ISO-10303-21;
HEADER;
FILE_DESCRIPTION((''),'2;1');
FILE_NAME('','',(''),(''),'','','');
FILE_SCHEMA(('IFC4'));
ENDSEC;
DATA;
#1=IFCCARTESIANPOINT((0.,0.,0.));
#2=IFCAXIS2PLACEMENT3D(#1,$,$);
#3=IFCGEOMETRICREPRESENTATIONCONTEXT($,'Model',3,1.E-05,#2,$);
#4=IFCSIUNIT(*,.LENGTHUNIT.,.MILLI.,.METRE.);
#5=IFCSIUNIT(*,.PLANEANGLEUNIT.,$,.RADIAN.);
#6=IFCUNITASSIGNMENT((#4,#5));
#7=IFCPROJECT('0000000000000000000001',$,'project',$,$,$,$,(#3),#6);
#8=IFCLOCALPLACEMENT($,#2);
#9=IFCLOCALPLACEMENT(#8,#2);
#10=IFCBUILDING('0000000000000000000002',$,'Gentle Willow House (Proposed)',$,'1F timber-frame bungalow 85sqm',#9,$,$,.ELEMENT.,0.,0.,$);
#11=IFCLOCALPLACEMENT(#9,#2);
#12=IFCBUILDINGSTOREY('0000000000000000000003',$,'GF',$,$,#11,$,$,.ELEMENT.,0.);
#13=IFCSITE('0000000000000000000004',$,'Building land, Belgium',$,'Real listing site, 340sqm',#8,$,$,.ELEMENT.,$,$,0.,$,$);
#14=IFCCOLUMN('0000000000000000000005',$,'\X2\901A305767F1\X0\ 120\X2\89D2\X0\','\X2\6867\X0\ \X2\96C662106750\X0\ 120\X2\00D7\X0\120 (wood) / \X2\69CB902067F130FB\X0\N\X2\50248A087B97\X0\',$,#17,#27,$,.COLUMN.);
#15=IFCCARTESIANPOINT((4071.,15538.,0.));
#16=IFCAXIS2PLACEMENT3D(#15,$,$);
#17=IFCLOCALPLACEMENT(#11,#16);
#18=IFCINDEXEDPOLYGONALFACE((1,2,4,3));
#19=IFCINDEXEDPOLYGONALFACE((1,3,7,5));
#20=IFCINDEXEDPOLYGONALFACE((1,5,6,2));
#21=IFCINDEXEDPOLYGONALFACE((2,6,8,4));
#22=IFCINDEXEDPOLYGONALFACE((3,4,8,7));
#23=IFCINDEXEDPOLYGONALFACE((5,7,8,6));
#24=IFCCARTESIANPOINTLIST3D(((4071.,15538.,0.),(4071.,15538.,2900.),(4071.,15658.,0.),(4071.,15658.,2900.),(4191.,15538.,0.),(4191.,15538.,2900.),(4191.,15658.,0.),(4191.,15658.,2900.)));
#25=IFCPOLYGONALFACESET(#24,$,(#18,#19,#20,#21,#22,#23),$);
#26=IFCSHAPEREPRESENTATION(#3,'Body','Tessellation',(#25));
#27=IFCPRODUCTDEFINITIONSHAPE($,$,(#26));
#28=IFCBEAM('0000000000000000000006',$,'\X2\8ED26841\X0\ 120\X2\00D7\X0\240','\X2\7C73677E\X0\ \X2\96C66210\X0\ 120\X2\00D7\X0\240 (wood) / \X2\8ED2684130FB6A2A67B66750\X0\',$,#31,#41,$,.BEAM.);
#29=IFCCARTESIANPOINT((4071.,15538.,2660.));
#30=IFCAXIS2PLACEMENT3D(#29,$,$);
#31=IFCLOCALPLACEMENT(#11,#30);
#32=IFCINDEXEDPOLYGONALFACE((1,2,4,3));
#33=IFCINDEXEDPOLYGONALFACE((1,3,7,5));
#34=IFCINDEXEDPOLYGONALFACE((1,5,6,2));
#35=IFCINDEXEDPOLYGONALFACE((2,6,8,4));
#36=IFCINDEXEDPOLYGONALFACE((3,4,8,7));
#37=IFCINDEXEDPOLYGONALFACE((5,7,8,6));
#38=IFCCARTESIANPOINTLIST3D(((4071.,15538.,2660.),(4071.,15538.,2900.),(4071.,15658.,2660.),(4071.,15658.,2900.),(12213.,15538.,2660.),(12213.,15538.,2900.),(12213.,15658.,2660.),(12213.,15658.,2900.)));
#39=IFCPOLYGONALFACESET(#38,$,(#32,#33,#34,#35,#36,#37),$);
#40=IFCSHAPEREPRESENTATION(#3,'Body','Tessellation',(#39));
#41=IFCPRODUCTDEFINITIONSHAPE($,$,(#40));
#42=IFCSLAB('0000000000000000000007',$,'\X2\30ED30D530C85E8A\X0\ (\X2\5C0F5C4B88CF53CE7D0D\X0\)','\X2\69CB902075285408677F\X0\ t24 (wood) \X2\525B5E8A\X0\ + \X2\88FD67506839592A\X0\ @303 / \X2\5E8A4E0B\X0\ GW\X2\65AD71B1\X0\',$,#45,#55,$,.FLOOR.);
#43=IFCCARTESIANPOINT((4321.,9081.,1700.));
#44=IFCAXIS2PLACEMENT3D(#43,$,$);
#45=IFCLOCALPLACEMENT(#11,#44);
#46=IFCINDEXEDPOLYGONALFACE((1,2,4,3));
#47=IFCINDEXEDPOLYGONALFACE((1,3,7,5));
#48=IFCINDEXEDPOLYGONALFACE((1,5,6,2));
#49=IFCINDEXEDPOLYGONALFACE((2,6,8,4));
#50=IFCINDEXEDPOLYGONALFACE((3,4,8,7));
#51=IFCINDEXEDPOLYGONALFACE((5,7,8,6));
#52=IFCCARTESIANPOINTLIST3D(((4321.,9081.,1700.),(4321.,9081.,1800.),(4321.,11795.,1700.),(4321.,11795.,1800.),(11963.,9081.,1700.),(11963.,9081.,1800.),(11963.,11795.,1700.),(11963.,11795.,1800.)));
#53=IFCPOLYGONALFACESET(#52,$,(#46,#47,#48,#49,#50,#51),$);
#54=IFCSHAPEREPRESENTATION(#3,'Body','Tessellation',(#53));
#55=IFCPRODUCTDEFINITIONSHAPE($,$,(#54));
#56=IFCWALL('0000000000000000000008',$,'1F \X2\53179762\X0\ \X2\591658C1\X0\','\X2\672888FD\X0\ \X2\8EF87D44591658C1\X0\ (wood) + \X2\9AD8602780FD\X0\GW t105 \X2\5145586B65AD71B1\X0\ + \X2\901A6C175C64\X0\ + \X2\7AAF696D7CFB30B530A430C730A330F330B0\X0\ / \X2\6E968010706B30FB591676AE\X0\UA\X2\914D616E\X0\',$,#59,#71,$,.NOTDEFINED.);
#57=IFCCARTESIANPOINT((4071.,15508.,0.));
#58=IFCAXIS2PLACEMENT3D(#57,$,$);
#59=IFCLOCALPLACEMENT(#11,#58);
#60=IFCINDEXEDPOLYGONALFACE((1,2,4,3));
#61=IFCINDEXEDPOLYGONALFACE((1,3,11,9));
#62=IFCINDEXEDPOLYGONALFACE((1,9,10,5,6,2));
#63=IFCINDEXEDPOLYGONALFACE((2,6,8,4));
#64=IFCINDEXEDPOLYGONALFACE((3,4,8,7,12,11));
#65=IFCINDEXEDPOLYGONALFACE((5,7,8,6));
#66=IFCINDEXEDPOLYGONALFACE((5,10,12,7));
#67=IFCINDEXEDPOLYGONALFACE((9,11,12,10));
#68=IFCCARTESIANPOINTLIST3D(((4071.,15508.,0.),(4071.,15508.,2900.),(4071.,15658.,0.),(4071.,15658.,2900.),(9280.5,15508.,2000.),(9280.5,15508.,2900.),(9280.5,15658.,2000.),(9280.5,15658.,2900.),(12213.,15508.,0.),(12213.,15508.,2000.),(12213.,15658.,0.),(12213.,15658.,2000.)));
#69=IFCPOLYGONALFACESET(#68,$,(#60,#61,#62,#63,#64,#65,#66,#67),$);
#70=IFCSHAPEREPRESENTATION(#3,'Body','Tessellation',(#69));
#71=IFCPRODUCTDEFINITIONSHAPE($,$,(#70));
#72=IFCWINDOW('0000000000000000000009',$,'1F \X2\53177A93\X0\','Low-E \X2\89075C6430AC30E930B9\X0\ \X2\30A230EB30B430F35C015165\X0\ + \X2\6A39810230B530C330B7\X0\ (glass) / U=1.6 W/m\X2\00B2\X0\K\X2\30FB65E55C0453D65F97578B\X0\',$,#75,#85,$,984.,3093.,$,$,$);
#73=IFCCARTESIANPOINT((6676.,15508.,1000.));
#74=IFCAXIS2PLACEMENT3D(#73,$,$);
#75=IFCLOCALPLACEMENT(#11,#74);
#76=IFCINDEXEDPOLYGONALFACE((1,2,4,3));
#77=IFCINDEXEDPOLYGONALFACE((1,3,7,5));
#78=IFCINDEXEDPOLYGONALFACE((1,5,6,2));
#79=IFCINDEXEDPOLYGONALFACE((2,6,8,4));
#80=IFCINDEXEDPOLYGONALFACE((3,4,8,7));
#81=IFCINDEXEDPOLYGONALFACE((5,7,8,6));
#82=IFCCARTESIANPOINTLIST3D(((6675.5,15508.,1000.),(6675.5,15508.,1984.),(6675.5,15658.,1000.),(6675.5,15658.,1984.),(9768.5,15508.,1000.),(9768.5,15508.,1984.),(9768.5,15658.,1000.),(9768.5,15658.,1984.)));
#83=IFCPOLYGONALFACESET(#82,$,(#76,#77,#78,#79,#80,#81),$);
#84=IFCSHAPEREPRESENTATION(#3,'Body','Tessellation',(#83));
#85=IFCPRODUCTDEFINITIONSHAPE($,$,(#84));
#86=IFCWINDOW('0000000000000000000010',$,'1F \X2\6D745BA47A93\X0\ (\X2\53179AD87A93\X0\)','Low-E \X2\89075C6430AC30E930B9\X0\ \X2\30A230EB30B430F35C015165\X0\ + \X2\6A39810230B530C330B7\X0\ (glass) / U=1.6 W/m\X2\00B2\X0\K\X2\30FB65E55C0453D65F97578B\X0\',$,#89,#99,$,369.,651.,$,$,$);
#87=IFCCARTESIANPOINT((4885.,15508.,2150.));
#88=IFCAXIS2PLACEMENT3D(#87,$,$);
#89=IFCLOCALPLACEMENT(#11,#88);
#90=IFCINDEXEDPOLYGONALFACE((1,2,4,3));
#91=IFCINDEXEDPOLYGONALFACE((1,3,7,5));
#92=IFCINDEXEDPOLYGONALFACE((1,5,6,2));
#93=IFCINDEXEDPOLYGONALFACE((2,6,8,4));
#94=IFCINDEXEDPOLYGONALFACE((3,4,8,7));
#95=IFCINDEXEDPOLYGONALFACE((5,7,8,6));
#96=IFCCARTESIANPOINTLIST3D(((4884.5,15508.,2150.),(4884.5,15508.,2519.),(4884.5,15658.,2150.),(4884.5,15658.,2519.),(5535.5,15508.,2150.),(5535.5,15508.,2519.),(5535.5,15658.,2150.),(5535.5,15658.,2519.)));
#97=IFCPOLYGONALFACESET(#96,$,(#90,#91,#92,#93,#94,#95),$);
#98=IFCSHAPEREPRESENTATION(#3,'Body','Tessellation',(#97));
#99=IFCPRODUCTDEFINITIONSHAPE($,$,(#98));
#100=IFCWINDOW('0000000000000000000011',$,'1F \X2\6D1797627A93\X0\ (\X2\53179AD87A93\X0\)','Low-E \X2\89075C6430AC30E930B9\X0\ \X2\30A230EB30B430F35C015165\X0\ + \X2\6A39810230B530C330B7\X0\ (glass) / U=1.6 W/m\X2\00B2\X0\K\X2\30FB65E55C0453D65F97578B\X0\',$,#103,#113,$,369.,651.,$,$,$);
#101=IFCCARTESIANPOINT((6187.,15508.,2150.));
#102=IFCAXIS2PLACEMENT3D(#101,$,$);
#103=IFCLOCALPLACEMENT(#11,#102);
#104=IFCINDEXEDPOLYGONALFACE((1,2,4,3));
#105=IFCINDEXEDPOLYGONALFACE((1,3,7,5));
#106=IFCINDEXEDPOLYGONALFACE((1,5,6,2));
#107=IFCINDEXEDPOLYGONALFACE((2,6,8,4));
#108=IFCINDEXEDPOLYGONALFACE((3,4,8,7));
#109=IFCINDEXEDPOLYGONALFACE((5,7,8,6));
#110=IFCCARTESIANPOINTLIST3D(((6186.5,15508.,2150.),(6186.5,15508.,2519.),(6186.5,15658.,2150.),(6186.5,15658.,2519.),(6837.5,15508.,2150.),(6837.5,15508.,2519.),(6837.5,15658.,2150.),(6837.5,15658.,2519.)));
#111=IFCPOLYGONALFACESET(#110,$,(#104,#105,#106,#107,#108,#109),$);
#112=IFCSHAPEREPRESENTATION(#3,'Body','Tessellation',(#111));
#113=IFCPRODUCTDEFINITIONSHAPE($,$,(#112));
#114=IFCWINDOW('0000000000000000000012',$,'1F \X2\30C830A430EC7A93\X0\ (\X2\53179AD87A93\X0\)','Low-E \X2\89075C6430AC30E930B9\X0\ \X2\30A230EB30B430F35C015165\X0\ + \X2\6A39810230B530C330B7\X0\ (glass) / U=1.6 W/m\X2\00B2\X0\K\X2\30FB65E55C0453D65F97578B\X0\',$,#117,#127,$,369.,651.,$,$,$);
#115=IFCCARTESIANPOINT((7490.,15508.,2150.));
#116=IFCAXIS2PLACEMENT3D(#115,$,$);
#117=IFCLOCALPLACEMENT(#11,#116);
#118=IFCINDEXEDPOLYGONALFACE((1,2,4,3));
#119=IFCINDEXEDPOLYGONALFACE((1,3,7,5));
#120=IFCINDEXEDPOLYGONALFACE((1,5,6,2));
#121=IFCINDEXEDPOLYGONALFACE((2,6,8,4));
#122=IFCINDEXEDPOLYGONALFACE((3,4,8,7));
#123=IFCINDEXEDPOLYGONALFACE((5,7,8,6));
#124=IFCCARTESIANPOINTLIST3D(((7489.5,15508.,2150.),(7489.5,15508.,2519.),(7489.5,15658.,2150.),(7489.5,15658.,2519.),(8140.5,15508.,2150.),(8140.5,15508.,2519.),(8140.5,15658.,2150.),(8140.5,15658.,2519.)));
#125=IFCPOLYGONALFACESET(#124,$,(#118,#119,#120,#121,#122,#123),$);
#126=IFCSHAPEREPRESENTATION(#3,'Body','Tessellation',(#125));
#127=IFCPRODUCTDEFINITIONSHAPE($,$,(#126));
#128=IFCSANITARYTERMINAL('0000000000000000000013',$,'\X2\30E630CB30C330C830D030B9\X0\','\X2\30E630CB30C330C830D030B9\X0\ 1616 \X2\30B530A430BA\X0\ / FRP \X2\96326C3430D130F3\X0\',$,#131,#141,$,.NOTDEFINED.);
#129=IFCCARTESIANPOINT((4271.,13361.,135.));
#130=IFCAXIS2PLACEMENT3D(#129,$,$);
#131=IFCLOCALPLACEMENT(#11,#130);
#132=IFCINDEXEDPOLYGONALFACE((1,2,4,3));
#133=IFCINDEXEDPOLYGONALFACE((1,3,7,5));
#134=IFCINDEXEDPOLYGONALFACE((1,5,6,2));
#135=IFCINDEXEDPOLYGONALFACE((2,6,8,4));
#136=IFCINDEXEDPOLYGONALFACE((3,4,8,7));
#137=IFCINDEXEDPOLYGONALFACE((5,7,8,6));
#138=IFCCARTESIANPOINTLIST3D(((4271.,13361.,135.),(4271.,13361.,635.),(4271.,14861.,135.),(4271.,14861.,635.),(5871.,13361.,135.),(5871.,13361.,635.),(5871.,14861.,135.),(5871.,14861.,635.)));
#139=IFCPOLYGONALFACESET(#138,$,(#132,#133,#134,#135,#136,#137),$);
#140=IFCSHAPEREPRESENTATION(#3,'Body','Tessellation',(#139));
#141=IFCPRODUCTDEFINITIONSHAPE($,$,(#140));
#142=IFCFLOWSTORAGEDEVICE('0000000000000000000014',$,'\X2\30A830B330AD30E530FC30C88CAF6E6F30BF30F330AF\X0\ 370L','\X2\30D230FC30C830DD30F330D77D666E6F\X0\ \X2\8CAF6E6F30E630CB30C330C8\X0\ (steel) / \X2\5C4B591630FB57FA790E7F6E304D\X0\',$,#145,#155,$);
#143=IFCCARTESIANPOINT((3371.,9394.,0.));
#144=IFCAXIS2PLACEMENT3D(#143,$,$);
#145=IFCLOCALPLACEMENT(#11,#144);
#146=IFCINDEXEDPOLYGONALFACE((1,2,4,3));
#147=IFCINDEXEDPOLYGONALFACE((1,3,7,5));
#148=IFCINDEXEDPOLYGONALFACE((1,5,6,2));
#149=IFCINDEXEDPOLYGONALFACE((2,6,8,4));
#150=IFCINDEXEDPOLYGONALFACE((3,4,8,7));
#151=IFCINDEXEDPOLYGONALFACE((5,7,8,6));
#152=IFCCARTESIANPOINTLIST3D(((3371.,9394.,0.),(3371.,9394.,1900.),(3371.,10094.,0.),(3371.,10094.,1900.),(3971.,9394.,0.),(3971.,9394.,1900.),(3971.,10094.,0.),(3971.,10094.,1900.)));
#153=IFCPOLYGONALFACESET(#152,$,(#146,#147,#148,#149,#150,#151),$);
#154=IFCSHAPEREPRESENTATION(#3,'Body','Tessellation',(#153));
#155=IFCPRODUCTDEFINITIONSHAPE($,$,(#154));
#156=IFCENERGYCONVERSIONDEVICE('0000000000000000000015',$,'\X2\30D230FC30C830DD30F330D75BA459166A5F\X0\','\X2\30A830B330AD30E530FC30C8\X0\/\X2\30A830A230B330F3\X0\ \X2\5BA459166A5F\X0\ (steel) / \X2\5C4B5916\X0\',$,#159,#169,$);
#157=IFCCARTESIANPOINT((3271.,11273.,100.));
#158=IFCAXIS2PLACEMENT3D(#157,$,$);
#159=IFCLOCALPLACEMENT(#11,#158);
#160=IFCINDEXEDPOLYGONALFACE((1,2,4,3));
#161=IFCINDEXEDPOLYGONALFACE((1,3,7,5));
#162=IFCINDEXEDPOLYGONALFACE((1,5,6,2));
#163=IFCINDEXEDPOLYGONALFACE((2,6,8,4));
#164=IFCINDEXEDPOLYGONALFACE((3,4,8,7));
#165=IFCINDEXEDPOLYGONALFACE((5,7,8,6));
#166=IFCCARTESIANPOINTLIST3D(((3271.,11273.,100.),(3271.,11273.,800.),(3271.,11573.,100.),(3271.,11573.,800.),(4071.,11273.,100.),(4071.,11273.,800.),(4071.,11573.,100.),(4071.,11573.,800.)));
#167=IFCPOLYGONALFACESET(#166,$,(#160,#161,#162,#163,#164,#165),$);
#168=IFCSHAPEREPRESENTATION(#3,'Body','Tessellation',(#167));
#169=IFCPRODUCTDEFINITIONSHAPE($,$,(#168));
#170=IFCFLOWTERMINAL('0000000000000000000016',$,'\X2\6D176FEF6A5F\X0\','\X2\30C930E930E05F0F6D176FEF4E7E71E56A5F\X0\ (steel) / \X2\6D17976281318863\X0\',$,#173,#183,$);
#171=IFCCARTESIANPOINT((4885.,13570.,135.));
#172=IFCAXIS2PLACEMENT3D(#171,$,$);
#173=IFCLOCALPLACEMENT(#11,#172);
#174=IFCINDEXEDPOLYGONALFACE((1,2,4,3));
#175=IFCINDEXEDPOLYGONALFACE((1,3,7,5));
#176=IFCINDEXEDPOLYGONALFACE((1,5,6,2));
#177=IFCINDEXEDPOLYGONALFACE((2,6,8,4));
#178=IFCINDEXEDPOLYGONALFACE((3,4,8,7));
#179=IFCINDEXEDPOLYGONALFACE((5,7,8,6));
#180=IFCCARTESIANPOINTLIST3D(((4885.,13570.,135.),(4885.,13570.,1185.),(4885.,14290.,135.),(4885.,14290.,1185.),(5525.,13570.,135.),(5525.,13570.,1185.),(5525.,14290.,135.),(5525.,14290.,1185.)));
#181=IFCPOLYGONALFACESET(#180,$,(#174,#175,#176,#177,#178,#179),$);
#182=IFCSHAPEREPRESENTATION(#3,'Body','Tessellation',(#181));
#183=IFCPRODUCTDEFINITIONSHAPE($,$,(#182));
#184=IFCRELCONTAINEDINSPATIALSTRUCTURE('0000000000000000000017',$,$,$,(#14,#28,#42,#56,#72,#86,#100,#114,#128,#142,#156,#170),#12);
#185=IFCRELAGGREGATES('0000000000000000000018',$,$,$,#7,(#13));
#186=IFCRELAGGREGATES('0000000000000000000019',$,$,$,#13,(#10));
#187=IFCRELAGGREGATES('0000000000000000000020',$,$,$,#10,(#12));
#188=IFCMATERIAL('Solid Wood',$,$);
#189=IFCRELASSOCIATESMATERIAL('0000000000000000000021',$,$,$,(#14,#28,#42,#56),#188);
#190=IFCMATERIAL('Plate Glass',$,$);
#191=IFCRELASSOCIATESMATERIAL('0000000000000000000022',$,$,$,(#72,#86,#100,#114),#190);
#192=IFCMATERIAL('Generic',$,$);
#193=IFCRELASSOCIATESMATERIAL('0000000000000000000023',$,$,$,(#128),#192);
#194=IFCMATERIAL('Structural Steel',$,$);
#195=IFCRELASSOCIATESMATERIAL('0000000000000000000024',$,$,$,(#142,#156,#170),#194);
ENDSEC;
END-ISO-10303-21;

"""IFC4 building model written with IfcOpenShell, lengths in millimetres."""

from ifc_helpers import new_model, si_unit, frame, frame_2d, origin, place, context, project, spatial, rectangle, extrude, material, element, fill, save


model = new_model("IFC4")

# Units and contexts
model_context = context("Model", 3, precision=1e-05, world=origin())
ifc_project = project(units=[si_unit("LENGTHUNIT", "METRE", prefix="MILLI"), si_unit("PLANEANGLEUNIT", "RADIAN")], contexts=[model_context])

# Site, building, storey
site_placement = place(None, origin())
site = spatial("IfcSite", under=ifc_project, at=site_placement, Name="Building land, Belgium", ObjectType="Real listing site, 340sqm", CompositionType="ELEMENT", RefElevation=0.0)
building_placement = place(site_placement, origin())
building = spatial("IfcBuilding", under=site, at=building_placement, Name="Gentle Willow House (Proposed)", ObjectType="1F timber-frame bungalow 85sqm", CompositionType="ELEMENT", ElevationOfRefHeight=0.0, ElevationOfTerrain=0.0)
storey_placement = place(building_placement, origin())
storey = spatial("IfcBuildingStorey", under=building, at=storey_placement, Name="GF", CompositionType="ELEMENT", Elevation=0.0)

# Column
ifc_material_1 = material(Name="Solid Wood")
column_1_placement = place(storey_placement, frame((4071.0, 15538.0, 0.0)))
element("IfcColumn", 1, at=column_1_placement, inside=storey, material=ifc_material_1, Name="通し柱 120角", Description="桧 集成材 120×120 (wood) / 構造柱・N値計算", PredefinedType="COLUMN", context=model_context, shape_type="SweptSolid", body=[
    extrude(rectangle(XDim=120.0, YDim=120.0, at=frame_2d((60.0, 60.0))), frame((4071.0, 15538.0, 0.0)), (0.0, 0.0, 1.0), 2900.0),
])

# Beam
beam_1_placement = place(storey_placement, frame((4071.0, 15538.0, 2660.0)))
element("IfcBeam", 2, at=beam_1_placement, inside=storey, material=ifc_material_1, Name="軒桁 120×240", Description="米松 集成 120×240 (wood) / 軒桁・横架材", PredefinedType="BEAM", context=model_context, shape_type="SweptSolid", body=[
    extrude(rectangle(XDim=8142.0, YDim=120.0, at=frame_2d((4071.0, 60.0))), frame((4071.0, 15538.0, 2660.0)), (0.0, 0.0, 1.0), 240.0),
])

# Slab
slab_placement = place(storey_placement, frame((4321.0, 9081.0, 1700.0)))
element("IfcSlab", 3, at=slab_placement, inside=storey, material=ifc_material_1, Name="ロフト床 (小屋裏収納)", Description="構造用合板 t24 (wood) 剛床 + 製材根太 @303 / 床下 GW断熱", PredefinedType="FLOOR", context=model_context, shape_type="SweptSolid", body=[
    extrude(rectangle(XDim=7642.0, YDim=2714.0, at=frame_2d((3821.0, 1357.0))), frame((4321.0, 9081.0, 1700.0)), (0.0, 0.0, 1.0), 100.0),
])

# Wall, openings, windows
wall_1_placement = place(storey_placement, frame((4071.0, 15508.0, 0.0)))
wall_1 = element("IfcWall", 4, at=wall_1_placement, inside=storey, material=ifc_material_1, Name="1F 北面 外壁", Description="木製 軸組外壁 (wood) + 高性能GW t105 充填断熱 + 通気層 + 窯業系サイディング / 準耐火・外皮UA配慮", PredefinedType="NOTDEFINED", context=model_context, shape_type="SweptSolid", body=[
    extrude(rectangle(XDim=8142.0, YDim=150.0, at=frame_2d((4071.0, 75.0))), frame((4071.0, 15508.0, 0.0)), (0.0, 0.0, 1.0), 2900.0),
])
opening_1_placement = place(storey_placement, frame((6676.0, 15508.0, 1000.0)))
opening_1 = element("IfcOpeningElement", 5, at=opening_1_placement, cuts=wall_1, PredefinedType="NOTDEFINED", context=model_context, shape_type="SweptSolid", body=[
    extrude(rectangle(XDim=3093.0, YDim=150.0, at=frame_2d((1546.0, 75.0))), frame((6676.0, 15508.0, 1000.0)), (0.0, 0.0, 1.0), 984.0),
])
opening_2_placement = place(storey_placement, frame((4885.0, 15508.0, 2150.0)))
opening_2 = element("IfcOpeningElement", 6, at=opening_2_placement, cuts=wall_1, PredefinedType="NOTDEFINED", context=model_context, shape_type="SweptSolid", body=[
    extrude(rectangle(XDim=651.0, YDim=150.0, at=frame_2d((325.0, 75.0))), frame((4885.0, 15508.0, 2150.0)), (0.0, 0.0, 1.0), 369.0),
])
opening_3_placement = place(storey_placement, frame((6187.0, 15508.0, 2150.0)))
opening_3 = element("IfcOpeningElement", 7, at=opening_3_placement, cuts=wall_1, PredefinedType="NOTDEFINED", context=model_context, shape_type="SweptSolid", body=[
    extrude(rectangle(XDim=651.0, YDim=150.0, at=frame_2d((325.0, 75.0))), frame((6187.0, 15508.0, 2150.0)), (0.0, 0.0, 1.0), 369.0),
])
opening_4_placement = place(storey_placement, frame((7490.0, 15508.0, 2150.0)))
opening_4 = element("IfcOpeningElement", 8, at=opening_4_placement, cuts=wall_1, PredefinedType="NOTDEFINED", context=model_context, shape_type="SweptSolid", body=[
    extrude(rectangle(XDim=651.0, YDim=150.0, at=frame_2d((325.0, 75.0))), frame((7490.0, 15508.0, 2150.0)), (0.0, 0.0, 1.0), 369.0),
])
ifc_material_2 = material(Name="Plate Glass")
window_1_placement = place(storey_placement, frame((6676.0, 15508.0, 1000.0)))
window_1 = element("IfcWindow", 9, at=window_1_placement, inside=storey, material=ifc_material_2, Name="1F 北窓", Description="Low-E 複層ガラス アルゴン封入 + 樹脂サッシ (glass) / U=1.6 W/m²K・日射取得型", OverallHeight=984.0, OverallWidth=3093.0, context=model_context, shape_type="SweptSolid", body=[
    extrude(rectangle(XDim=3093.0, YDim=150.0, at=frame_2d((1546.0, 75.0))), frame((6676.0, 15508.0, 1000.0)), (0.0, 0.0, 1.0), 984.0),
])
fill(opening_1, window_1)
window_2_placement = place(storey_placement, frame((4885.0, 15508.0, 2150.0)))
window_2 = element("IfcWindow", 10, at=window_2_placement, inside=storey, material=ifc_material_2, Name="1F 浴室窓 (北高窓)", Description="Low-E 複層ガラス アルゴン封入 + 樹脂サッシ (glass) / U=1.6 W/m²K・日射取得型", OverallHeight=369.0, OverallWidth=651.0, context=model_context, shape_type="SweptSolid", body=[
    extrude(rectangle(XDim=651.0, YDim=150.0, at=frame_2d((325.0, 75.0))), frame((4885.0, 15508.0, 2150.0)), (0.0, 0.0, 1.0), 369.0),
])
fill(opening_2, window_2)
window_3_placement = place(storey_placement, frame((6187.0, 15508.0, 2150.0)))
window_3 = element("IfcWindow", 11, at=window_3_placement, inside=storey, material=ifc_material_2, Name="1F 洗面窓 (北高窓)", Description="Low-E 複層ガラス アルゴン封入 + 樹脂サッシ (glass) / U=1.6 W/m²K・日射取得型", OverallHeight=369.0, OverallWidth=651.0, context=model_context, shape_type="SweptSolid", body=[
    extrude(rectangle(XDim=651.0, YDim=150.0, at=frame_2d((325.0, 75.0))), frame((6187.0, 15508.0, 2150.0)), (0.0, 0.0, 1.0), 369.0),
])
fill(opening_3, window_3)
window_4_placement = place(storey_placement, frame((7490.0, 15508.0, 2150.0)))
window_4 = element("IfcWindow", 12, at=window_4_placement, inside=storey, material=ifc_material_2, Name="1F トイレ窓 (北高窓)", Description="Low-E 複層ガラス アルゴン封入 + 樹脂サッシ (glass) / U=1.6 W/m²K・日射取得型", OverallHeight=369.0, OverallWidth=651.0, context=model_context, shape_type="SweptSolid", body=[
    extrude(rectangle(XDim=651.0, YDim=150.0, at=frame_2d((325.0, 75.0))), frame((7490.0, 15508.0, 2150.0)), (0.0, 0.0, 1.0), 369.0),
])
fill(opening_4, window_4)

# Sanitary terminal
ifc_material_3 = material(Name="Generic")
sanitary_terminal_placement = place(storey_placement, frame((4271.0, 13361.0, 135.0)))
element("IfcSanitaryTerminal", 13, at=sanitary_terminal_placement, inside=storey, material=ifc_material_3, Name="ユニットバス", Description="ユニットバス 1616 サイズ / FRP 防水パン", PredefinedType="NOTDEFINED", context=model_context, shape_type="SweptSolid", body=[
    extrude(rectangle(XDim=1600.0, YDim=1500.0, at=frame_2d((800.0, 750.0))), frame((4271.0, 13361.0, 135.0)), (0.0, 0.0, 1.0), 500.0),
])

# Flow storage device
ifc_material_4 = material(Name="Structural Steel")
flow_storage_device_placement = place(storey_placement, frame((3371.0, 9394.0, 0.0)))
element("IfcFlowStorageDevice", 14, at=flow_storage_device_placement, inside=storey, material=ifc_material_4, Name="エコキュート貯湯タンク 370L", Description="ヒートポンプ給湯 貯湯ユニット (steel) / 屋外・基礎置き", context=model_context, shape_type="SweptSolid", body=[
    extrude(rectangle(XDim=600.0, YDim=700.0, at=frame_2d((300.0, 350.0))), frame((3371.0, 9394.0, 0.0)), (0.0, 0.0, 1.0), 1900.0),
])

# Energy conversion device
energy_conversion_device_placement = place(storey_placement, frame((3271.0, 11273.0, 100.0)))
element("IfcEnergyConversionDevice", 15, at=energy_conversion_device_placement, inside=storey, material=ifc_material_4, Name="ヒートポンプ室外機", Description="エコキュート/エアコン 室外機 (steel) / 屋外", context=model_context, shape_type="SweptSolid", body=[
    extrude(rectangle(XDim=800.0, YDim=300.0, at=frame_2d((400.0, 150.0))), frame((3271.0, 11273.0, 100.0)), (0.0, 0.0, 1.0), 700.0),
])

# Flow terminal
flow_terminal_placement = place(storey_placement, frame((4885.0, 13570.0, 135.0)))
element("IfcFlowTerminal", 16, at=flow_terminal_placement, inside=storey, material=ifc_material_4, Name="洗濯機", Description="ドラム式洗濯乾燥機 (steel) / 洗面脱衣", context=model_context, shape_type="SweptSolid", body=[
    extrude(rectangle(XDim=640.0, YDim=720.0, at=frame_2d((320.0, 360.0))), frame((4885.0, 13570.0, 135.0)), (0.0, 0.0, 1.0), 1050.0),
])

save(model, "model.ifc")
